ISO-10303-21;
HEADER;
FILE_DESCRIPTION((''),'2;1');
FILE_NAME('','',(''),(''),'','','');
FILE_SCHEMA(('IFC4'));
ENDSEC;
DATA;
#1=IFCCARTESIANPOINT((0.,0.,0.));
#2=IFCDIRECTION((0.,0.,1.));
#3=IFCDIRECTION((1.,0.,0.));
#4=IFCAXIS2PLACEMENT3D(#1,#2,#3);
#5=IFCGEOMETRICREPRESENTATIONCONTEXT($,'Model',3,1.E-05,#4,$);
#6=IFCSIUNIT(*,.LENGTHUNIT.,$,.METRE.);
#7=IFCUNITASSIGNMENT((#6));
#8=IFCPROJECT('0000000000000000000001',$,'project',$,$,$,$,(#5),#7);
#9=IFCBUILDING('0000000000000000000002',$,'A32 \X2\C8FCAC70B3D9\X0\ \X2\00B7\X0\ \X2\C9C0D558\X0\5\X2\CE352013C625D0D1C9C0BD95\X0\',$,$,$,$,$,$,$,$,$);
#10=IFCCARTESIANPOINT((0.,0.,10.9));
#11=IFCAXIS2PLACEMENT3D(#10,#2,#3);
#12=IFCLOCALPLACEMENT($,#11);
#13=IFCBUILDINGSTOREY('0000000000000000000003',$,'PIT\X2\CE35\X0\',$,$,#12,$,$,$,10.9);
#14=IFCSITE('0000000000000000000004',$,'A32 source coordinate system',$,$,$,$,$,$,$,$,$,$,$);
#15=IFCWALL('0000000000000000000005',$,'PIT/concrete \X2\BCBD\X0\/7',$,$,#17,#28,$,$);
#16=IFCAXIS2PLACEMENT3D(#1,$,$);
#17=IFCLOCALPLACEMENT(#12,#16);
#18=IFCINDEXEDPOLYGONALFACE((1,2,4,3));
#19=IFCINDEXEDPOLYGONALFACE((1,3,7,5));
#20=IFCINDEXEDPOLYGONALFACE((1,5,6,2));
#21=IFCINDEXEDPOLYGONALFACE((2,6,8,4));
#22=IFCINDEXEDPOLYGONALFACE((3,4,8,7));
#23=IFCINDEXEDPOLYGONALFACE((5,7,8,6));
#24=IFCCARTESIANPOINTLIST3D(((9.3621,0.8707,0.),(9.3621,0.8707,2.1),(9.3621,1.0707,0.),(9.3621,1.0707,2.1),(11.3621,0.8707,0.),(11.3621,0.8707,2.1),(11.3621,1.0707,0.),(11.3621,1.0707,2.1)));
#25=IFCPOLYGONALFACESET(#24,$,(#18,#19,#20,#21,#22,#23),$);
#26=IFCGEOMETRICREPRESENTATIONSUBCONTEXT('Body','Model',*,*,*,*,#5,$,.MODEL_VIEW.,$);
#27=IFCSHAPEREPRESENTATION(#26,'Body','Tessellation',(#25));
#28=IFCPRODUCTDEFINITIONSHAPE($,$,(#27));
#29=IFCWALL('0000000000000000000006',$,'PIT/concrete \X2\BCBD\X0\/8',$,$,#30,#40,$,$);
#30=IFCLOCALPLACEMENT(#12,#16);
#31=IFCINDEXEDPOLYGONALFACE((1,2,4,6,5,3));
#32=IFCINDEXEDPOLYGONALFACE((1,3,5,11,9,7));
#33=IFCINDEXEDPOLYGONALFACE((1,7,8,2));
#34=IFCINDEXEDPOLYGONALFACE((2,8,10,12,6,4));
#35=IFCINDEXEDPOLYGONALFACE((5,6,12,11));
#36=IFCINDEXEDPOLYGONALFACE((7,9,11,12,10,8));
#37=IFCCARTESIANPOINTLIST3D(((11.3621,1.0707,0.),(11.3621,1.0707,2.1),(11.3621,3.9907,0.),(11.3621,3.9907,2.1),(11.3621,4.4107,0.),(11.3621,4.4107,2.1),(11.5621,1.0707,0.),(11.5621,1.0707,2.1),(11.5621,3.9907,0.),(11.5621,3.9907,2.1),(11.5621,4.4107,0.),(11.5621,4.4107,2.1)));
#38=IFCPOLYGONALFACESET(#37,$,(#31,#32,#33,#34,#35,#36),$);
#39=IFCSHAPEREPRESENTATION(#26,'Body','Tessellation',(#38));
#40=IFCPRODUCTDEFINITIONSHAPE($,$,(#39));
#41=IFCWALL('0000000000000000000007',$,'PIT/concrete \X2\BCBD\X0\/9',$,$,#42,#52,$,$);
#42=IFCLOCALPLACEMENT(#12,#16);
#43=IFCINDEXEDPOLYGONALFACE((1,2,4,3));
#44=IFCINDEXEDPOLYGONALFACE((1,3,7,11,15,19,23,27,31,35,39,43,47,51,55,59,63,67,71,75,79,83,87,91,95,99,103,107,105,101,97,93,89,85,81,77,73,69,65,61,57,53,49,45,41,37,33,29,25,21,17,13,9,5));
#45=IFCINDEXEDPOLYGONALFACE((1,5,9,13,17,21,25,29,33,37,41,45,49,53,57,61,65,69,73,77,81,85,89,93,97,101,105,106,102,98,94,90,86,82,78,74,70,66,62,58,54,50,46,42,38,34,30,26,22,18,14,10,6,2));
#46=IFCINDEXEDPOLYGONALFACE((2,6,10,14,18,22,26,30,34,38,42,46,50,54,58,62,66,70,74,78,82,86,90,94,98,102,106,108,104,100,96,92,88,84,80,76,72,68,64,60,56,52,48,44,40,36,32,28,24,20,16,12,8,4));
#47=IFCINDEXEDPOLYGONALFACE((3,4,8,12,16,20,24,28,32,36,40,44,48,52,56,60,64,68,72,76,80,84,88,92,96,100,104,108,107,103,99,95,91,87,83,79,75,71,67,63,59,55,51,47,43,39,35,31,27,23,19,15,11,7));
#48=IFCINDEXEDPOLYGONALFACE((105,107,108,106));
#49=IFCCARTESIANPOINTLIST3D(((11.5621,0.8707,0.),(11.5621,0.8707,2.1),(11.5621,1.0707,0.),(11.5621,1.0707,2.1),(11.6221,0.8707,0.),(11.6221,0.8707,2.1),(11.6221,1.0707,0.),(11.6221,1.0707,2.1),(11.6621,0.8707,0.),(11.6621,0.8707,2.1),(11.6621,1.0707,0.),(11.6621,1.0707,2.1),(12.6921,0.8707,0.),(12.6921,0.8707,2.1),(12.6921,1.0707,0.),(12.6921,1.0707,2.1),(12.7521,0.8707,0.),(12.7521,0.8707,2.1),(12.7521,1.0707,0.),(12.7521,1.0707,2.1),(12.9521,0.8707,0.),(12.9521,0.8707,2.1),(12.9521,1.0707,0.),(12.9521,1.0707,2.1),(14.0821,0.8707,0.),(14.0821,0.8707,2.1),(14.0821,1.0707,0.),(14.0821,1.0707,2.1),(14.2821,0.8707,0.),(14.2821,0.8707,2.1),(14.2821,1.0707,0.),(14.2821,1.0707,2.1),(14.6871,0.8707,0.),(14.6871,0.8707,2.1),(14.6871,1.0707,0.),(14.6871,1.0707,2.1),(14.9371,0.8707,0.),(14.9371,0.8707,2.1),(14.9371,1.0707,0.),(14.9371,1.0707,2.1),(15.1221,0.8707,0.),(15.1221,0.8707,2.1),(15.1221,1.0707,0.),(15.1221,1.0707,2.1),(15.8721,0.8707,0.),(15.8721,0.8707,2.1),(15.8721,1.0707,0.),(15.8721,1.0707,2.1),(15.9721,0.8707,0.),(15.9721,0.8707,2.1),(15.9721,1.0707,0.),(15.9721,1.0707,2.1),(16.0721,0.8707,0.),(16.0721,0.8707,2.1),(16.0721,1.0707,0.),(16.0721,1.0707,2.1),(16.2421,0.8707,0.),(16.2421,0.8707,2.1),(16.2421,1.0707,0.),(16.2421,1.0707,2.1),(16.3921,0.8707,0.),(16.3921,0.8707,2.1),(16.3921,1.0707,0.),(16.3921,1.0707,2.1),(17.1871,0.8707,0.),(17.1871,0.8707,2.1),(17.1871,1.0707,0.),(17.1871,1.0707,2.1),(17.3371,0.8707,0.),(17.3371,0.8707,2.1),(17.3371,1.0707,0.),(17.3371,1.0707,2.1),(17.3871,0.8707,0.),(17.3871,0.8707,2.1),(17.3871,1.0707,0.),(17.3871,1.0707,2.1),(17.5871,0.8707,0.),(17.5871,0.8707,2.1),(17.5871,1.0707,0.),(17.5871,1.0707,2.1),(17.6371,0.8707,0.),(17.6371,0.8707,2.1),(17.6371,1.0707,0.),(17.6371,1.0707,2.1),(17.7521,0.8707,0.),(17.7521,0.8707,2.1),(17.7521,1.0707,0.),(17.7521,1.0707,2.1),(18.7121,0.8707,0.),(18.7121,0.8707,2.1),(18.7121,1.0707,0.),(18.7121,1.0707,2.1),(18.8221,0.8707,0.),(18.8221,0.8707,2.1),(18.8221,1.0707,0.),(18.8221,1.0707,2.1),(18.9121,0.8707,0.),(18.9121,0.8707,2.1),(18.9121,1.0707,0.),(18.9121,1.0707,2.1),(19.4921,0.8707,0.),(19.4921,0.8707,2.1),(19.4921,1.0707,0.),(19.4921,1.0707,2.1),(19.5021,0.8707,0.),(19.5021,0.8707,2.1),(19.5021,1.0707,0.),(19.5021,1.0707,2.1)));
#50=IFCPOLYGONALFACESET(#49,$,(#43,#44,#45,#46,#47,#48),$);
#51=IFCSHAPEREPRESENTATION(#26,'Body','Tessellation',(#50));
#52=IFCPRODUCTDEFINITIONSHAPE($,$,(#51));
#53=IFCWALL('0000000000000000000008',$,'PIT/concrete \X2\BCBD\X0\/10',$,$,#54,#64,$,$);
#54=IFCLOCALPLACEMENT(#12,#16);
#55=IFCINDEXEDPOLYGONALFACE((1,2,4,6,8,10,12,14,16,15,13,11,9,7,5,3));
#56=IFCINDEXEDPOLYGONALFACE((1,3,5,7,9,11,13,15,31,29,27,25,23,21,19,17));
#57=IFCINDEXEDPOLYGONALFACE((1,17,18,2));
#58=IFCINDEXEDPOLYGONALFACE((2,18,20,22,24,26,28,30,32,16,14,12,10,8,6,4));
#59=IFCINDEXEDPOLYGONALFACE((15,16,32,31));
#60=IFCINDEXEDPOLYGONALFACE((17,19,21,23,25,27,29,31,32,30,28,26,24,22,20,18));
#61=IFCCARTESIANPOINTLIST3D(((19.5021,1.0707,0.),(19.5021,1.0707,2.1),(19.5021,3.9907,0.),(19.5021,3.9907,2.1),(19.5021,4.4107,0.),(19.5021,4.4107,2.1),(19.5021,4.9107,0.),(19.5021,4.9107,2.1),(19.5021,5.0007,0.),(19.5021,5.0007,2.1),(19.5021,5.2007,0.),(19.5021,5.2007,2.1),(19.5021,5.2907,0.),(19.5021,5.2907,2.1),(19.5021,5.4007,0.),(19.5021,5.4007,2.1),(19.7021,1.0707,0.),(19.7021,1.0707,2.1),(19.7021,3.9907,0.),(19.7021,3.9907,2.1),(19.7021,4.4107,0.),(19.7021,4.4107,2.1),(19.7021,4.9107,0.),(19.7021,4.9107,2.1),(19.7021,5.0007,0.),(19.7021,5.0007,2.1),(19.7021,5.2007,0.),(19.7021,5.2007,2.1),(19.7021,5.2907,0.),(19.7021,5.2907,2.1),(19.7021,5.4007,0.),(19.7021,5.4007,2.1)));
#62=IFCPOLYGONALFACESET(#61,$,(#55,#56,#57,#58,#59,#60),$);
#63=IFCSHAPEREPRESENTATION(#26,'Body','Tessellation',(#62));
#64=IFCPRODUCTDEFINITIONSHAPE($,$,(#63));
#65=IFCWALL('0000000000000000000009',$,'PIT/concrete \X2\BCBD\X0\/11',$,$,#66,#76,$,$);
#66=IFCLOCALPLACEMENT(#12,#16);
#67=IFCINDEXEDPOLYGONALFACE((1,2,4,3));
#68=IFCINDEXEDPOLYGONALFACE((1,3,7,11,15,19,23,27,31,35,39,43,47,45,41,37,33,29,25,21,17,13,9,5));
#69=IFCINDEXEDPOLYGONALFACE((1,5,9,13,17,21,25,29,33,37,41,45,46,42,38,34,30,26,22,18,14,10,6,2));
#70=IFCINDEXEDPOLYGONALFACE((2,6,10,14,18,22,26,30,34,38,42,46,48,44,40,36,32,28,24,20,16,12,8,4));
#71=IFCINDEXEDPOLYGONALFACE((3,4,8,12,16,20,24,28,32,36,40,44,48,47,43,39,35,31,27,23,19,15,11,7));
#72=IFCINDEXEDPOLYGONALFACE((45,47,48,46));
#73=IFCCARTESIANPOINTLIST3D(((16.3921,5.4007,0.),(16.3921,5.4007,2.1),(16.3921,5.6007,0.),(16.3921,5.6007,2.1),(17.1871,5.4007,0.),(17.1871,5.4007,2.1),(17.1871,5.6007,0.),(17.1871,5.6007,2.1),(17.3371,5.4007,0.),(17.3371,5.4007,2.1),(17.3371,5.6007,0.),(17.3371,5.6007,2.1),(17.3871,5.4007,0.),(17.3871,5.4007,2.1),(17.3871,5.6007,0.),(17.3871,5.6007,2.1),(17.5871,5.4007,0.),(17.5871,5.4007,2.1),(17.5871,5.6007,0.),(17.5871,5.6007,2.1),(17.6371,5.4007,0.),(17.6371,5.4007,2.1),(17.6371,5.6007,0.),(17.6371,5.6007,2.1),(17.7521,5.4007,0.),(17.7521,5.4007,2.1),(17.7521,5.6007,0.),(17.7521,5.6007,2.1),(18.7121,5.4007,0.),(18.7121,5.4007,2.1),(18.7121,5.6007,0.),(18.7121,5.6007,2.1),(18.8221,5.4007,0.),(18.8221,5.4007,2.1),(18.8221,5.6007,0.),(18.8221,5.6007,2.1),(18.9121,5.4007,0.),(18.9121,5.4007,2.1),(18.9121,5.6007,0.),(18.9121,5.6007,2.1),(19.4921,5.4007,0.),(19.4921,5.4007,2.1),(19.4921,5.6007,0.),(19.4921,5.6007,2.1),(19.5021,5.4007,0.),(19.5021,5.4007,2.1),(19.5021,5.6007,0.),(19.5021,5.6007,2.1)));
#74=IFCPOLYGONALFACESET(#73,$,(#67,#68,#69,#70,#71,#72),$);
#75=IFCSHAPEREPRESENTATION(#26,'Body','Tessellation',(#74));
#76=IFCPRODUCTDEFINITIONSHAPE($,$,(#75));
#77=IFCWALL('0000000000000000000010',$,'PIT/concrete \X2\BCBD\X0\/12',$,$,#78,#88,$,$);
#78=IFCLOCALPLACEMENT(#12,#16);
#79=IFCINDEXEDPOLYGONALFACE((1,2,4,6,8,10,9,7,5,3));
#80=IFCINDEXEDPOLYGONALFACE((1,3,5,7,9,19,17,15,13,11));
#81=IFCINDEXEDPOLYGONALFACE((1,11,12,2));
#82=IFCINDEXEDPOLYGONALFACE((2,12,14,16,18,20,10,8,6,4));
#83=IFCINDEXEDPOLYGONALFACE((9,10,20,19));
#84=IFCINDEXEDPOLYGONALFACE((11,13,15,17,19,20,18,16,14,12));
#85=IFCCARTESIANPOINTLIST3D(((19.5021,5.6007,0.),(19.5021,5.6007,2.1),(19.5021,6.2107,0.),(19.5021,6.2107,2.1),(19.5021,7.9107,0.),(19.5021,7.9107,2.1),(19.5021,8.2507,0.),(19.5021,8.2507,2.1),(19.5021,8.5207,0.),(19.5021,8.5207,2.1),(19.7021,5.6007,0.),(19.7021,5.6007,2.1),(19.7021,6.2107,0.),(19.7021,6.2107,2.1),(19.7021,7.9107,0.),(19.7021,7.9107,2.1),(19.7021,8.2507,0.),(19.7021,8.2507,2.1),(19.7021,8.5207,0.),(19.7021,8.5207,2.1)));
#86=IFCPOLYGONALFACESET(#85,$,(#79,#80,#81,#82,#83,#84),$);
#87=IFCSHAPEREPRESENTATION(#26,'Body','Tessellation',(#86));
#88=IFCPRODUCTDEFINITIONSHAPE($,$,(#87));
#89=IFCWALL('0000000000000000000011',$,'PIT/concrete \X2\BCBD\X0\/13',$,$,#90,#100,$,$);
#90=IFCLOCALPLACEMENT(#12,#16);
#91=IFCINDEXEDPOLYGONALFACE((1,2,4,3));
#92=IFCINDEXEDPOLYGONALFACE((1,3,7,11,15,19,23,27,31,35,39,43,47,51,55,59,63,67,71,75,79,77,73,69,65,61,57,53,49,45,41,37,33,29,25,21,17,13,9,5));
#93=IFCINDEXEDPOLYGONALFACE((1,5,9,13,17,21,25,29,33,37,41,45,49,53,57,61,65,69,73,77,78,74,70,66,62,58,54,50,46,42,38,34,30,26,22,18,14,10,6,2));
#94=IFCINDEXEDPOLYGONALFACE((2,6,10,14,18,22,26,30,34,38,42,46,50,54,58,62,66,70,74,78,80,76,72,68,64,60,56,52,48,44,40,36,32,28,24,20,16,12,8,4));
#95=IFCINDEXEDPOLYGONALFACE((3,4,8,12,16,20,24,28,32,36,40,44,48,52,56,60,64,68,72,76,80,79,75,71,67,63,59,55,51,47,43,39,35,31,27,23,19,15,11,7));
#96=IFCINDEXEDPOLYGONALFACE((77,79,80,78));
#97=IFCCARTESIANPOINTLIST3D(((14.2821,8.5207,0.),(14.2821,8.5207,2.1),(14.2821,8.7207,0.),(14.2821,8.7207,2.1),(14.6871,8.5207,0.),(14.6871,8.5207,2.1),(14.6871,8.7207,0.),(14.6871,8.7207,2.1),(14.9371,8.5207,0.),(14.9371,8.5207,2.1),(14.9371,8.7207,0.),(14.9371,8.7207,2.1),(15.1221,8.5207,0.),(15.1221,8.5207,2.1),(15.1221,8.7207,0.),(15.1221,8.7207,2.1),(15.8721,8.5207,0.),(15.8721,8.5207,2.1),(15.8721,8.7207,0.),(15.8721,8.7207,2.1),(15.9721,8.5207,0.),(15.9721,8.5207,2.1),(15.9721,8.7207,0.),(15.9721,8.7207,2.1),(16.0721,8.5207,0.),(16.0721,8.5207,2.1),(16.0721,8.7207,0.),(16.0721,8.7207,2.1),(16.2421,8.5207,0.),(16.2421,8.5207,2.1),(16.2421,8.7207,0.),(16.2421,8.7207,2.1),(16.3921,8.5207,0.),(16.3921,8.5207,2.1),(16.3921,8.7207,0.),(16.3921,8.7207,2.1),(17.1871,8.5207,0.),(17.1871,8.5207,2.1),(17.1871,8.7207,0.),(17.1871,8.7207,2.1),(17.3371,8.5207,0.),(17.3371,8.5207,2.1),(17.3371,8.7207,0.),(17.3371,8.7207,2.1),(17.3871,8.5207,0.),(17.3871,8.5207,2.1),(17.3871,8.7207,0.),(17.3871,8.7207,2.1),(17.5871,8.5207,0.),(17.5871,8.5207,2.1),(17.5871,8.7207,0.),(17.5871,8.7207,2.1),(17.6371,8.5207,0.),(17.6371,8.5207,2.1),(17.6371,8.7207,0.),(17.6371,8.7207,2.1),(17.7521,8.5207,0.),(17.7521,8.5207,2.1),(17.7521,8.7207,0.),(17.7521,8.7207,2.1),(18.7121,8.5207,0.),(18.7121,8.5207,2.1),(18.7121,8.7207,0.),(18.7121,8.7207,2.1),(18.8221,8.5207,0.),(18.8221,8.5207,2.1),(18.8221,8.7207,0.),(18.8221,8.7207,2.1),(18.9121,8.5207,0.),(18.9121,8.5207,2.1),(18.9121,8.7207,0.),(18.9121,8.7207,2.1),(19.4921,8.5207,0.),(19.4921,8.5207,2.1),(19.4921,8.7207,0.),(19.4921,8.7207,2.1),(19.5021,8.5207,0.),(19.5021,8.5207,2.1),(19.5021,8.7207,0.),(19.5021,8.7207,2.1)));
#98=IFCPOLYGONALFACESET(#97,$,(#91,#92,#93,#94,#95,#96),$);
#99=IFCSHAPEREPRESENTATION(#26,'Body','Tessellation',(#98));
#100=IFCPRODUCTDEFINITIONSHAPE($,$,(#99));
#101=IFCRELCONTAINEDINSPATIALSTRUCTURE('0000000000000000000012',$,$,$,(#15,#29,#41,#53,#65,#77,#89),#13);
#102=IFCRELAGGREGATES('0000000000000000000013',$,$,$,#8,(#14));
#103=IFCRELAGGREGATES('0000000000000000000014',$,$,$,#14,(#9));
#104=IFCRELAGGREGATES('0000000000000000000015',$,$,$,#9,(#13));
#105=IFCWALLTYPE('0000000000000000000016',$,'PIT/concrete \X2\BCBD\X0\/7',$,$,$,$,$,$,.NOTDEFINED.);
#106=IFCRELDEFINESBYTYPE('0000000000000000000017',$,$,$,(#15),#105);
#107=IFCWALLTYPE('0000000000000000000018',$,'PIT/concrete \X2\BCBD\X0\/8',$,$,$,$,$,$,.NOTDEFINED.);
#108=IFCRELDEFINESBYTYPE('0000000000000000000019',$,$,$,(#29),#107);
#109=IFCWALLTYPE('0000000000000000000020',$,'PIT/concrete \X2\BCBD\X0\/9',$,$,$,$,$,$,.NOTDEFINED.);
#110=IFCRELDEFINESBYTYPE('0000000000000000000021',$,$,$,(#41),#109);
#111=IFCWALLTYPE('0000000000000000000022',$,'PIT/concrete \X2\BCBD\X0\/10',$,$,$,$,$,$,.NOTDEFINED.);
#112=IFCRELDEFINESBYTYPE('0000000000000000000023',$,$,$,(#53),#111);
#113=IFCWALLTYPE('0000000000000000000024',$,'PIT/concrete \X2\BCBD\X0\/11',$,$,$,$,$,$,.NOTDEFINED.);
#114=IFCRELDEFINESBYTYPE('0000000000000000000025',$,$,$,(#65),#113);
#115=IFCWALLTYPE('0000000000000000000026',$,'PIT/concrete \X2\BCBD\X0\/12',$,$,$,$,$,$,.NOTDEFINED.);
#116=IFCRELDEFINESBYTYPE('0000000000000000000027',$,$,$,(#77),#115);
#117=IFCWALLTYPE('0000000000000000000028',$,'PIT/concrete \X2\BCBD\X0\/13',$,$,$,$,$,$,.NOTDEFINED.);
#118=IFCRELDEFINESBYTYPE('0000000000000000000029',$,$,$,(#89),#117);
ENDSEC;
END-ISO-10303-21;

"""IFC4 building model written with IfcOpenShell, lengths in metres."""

from ifc_helpers import new_model, si_unit, frame, origin, origin_with_axes, place, context, subcontext, project, spatial, polyline, outline, extrude, source, transform, mapped, type_object, type_shapes, element, save


model = new_model("IFC4")

# Units and contexts
model_context = context("Model", 3, precision=1e-05, world=origin_with_axes())
body_context = subcontext(model_context, "Body", "Model", "MODEL_VIEW")
ifc_project = project(units=[si_unit("LENGTHUNIT", "METRE")], contexts=[model_context])

# Site, building, storey
site = spatial("IfcSite", under=ifc_project, Name="A32 source coordinate system")
building = spatial("IfcBuilding", under=site, Name="A32 주거동 · 지하5층–옥탑지붕")
storey_placement = place(None, frame((0.0, 0.0, 10.9), z_axis=(0.0, 0.0, 1.0), x_axis=(1.0, 0.0, 0.0)))
storey = spatial("IfcBuildingStorey", under=building, at=storey_placement, Name="PIT층", Elevation=10.9)

# Walls
wall_type_1 = type_object("IfcWallType", Name="PIT/concrete 벽/7", PredefinedType="NOTDEFINED")
shared_shape_1 = source(origin(), body_context, "Body", "SweptSolid", [
    extrude(outline(polyline([(9.3621, 0.8707), (9.3621, 1.0707), (11.3621, 1.0707), (11.3621, 0.8707), (9.3621, 0.8707)])), origin(), (0.0, 0.0, 1.0), 2.1),
])
type_shapes(wall_type_1, [shared_shape_1])
wall_1_placement = place(storey_placement, origin_with_axes())
element("IfcWall", 1, at=wall_1_placement, inside=storey, type_object=wall_type_1, Name="PIT/concrete 벽/7", context=body_context, shape_type="MappedRepresentation", body=[
    mapped(shared_shape_1, transform((0.0, 0.0, 0.0), scale=1.0)),
])
wall_type_2 = type_object("IfcWallType", Name="PIT/concrete 벽/8", PredefinedType="NOTDEFINED")
shared_shape_2 = source(origin(), body_context, "Body", "SweptSolid", [
    extrude(outline(polyline([(11.5621, 4.4107), (11.5621, 3.9907), (11.5621, 1.0707), (11.3621, 1.0707), (11.3621, 3.9907), (11.3621, 4.4107), (11.5621, 4.4107)])), origin(), (0.0, 0.0, 1.0), 2.1),
])
type_shapes(wall_type_2, [shared_shape_2])
wall_2_placement = place(storey_placement, origin_with_axes())
element("IfcWall", 2, at=wall_2_placement, inside=storey, type_object=wall_type_2, Name="PIT/concrete 벽/8", context=body_context, shape_type="MappedRepresentation", body=[
    mapped(shared_shape_2, transform((0.0, 0.0, 0.0), scale=1.0)),
])
wall_type_3 = type_object("IfcWallType", Name="PIT/concrete 벽/9", PredefinedType="NOTDEFINED")
shared_shape_3 = source(origin(), body_context, "Body", "SweptSolid", [
    extrude(outline(polyline([(12.6921, 1.0707), (12.7521, 1.0707), (12.9521, 1.0707), (14.0821, 1.0707), (14.2821, 1.0707), (14.6871, 1.0707), (14.9371, 1.0707), (15.1221, 1.0707), (15.8721, 1.0707), (15.9721, 1.0707), (16.0721, 1.0707), (16.2421, 1.0707), (16.3921, 1.0707), (17.1871, 1.0707), (17.3371, 1.0707), (17.3871, 1.0707), (17.5871, 1.0707), (17.6371, 1.0707), (17.7521, 1.0707), (18.7121, 1.0707), (18.8221, 1.0707), (18.9121, 1.0707), (19.4921, 1.0707), (19.5021, 1.0707), (19.5021, 0.8707), (19.4921, 0.8707), (18.9121, 0.8707), (18.8221, 0.8707), (18.7121, 0.8707), (17.7521, 0.8707), (17.6371, 0.8707), (17.5871, 0.8707), (17.3871, 0.8707), (17.3371, 0.8707), (17.1871, 0.8707), (16.3921, 0.8707), (16.2421, 0.8707), (16.0721, 0.8707), (15.9721, 0.8707), (15.8721, 0.8707), (15.1221, 0.8707), (14.9371, 0.8707), (14.6871, 0.8707), (14.2821, 0.8707), (14.0821, 0.8707), (12.9521, 0.8707), (12.7521, 0.8707), (12.6921, 0.8707), (11.6621, 0.8707), (11.6221, 0.8707), (11.5621, 0.8707), (11.5621, 1.0707), (11.6221, 1.0707), (11.6621, 1.0707), (12.6921, 1.0707)])), origin(), (0.0, 0.0, 1.0), 2.1),
])
type_shapes(wall_type_3, [shared_shape_3])
wall_3_placement = place(storey_placement, origin_with_axes())
element("IfcWall", 3, at=wall_3_placement, inside=storey, type_object=wall_type_3, Name="PIT/concrete 벽/9", context=body_context, shape_type="MappedRepresentation", body=[
    mapped(shared_shape_3, transform((0.0, 0.0, 0.0), scale=1.0)),
])
wall_type_4 = type_object("IfcWallType", Name="PIT/concrete 벽/10", PredefinedType="NOTDEFINED")
shared_shape_4 = source(origin(), body_context, "Body", "SweptSolid", [
    extrude(outline(polyline([(19.5021, 4.9107), (19.5021, 5.0007), (19.5021, 5.2007), (19.5021, 5.2907), (19.5021, 5.4007), (19.7021, 5.4007), (19.7021, 5.2907), (19.7021, 5.2007), (19.7021, 5.0007), (19.7021, 4.9107), (19.7021, 4.4107), (19.7021, 3.9907), (19.7021, 1.0707), (19.5021, 1.0707), (19.5021, 3.9907), (19.5021, 4.4107), (19.5021, 4.9107)])), origin(), (0.0, 0.0, 1.0), 2.1),
])
type_shapes(wall_type_4, [shared_shape_4])
wall_4_placement = place(storey_placement, origin_with_axes())
element("IfcWall", 4, at=wall_4_placement, inside=storey, type_object=wall_type_4, Name="PIT/concrete 벽/10", context=body_context, shape_type="MappedRepresentation", body=[
    mapped(shared_shape_4, transform((0.0, 0.0, 0.0), scale=1.0)),
])
wall_type_5 = type_object("IfcWallType", Name="PIT/concrete 벽/11", PredefinedType="NOTDEFINED")
shared_shape_5 = source(origin(), body_context, "Body", "SweptSolid", [
    extrude(outline(polyline([(18.8221, 5.4007), (18.7121, 5.4007), (17.7521, 5.4007), (17.6371, 5.4007), (17.5871, 5.4007), (17.3871, 5.4007), (17.3371, 5.4007), (17.1871, 5.4007), (16.3921, 5.4007), (16.3921, 5.6007), (17.1871, 5.6007), (17.3371, 5.6007), (17.3871, 5.6007), (17.5871, 5.6007), (17.6371, 5.6007), (17.7521, 5.6007), (18.7121, 5.6007), (18.8221, 5.6007), (18.9121, 5.6007), (19.4921, 5.6007), (19.5021, 5.6007), (19.5021, 5.4007), (19.4921, 5.4007), (18.9121, 5.4007), (18.8221, 5.4007)])), origin(), (0.0, 0.0, 1.0), 2.1),
])
type_shapes(wall_type_5, [shared_shape_5])
wall_5_placement = place(storey_placement, origin_with_axes())
element("IfcWall", 5, at=wall_5_placement, inside=storey, type_object=wall_type_5, Name="PIT/concrete 벽/11", context=body_context, shape_type="MappedRepresentation", body=[
    mapped(shared_shape_5, transform((0.0, 0.0, 0.0), scale=1.0)),
])
wall_type_6 = type_object("IfcWallType", Name="PIT/concrete 벽/12", PredefinedType="NOTDEFINED")
shared_shape_6 = source(origin(), body_context, "Body", "SweptSolid", [
    extrude(outline(polyline([(19.5021, 8.2507), (19.5021, 8.5207), (19.7021, 8.5207), (19.7021, 8.2507), (19.7021, 7.9107), (19.7021, 6.2107), (19.7021, 5.6007), (19.5021, 5.6007), (19.5021, 6.2107), (19.5021, 7.9107), (19.5021, 8.2507)])), origin(), (0.0, 0.0, 1.0), 2.1),
])
type_shapes(wall_type_6, [shared_shape_6])
wall_6_placement = place(storey_placement, origin_with_axes())
element("IfcWall", 6, at=wall_6_placement, inside=storey, type_object=wall_type_6, Name="PIT/concrete 벽/12", context=body_context, shape_type="MappedRepresentation", body=[
    mapped(shared_shape_6, transform((0.0, 0.0, 0.0), scale=1.0)),
])
wall_type_7 = type_object("IfcWallType", Name="PIT/concrete 벽/13", PredefinedType="NOTDEFINED")
shared_shape_7 = source(origin(), body_context, "Body", "SweptSolid", [
    extrude(outline(polyline([(18.8221, 8.5207), (18.7121, 8.5207), (17.7521, 8.5207), (17.6371, 8.5207), (17.5871, 8.5207), (17.3871, 8.5207), (17.3371, 8.5207), (17.1871, 8.5207), (16.3921, 8.5207), (16.2421, 8.5207), (16.0721, 8.5207), (15.9721, 8.5207), (15.8721, 8.5207), (15.1221, 8.5207), (14.9371, 8.5207), (14.6871, 8.5207), (14.2821, 8.5207), (14.2821, 8.7207), (14.6871, 8.7207), (14.9371, 8.7207), (15.1221, 8.7207), (15.8721, 8.7207), (15.9721, 8.7207), (16.0721, 8.7207), (16.2421, 8.7207), (16.3921, 8.7207), (17.1871, 8.7207), (17.3371, 8.7207), (17.3871, 8.7207), (17.5871, 8.7207), (17.6371, 8.7207), (17.7521, 8.7207), (18.7121, 8.7207), (18.8221, 8.7207), (18.9121, 8.7207), (19.4921, 8.7207), (19.5021, 8.7207), (19.5021, 8.5207), (19.4921, 8.5207), (18.9121, 8.5207), (18.8221, 8.5207)])), origin(), (0.0, 0.0, 1.0), 2.1),
])
type_shapes(wall_type_7, [shared_shape_7])
wall_7_placement = place(storey_placement, origin_with_axes())
element("IfcWall", 7, at=wall_7_placement, inside=storey, type_object=wall_type_7, Name="PIT/concrete 벽/13", context=body_context, shape_type="MappedRepresentation", body=[
    mapped(shared_shape_7, transform((0.0, 0.0, 0.0), scale=1.0)),
])

save(model, "model.ifc")
